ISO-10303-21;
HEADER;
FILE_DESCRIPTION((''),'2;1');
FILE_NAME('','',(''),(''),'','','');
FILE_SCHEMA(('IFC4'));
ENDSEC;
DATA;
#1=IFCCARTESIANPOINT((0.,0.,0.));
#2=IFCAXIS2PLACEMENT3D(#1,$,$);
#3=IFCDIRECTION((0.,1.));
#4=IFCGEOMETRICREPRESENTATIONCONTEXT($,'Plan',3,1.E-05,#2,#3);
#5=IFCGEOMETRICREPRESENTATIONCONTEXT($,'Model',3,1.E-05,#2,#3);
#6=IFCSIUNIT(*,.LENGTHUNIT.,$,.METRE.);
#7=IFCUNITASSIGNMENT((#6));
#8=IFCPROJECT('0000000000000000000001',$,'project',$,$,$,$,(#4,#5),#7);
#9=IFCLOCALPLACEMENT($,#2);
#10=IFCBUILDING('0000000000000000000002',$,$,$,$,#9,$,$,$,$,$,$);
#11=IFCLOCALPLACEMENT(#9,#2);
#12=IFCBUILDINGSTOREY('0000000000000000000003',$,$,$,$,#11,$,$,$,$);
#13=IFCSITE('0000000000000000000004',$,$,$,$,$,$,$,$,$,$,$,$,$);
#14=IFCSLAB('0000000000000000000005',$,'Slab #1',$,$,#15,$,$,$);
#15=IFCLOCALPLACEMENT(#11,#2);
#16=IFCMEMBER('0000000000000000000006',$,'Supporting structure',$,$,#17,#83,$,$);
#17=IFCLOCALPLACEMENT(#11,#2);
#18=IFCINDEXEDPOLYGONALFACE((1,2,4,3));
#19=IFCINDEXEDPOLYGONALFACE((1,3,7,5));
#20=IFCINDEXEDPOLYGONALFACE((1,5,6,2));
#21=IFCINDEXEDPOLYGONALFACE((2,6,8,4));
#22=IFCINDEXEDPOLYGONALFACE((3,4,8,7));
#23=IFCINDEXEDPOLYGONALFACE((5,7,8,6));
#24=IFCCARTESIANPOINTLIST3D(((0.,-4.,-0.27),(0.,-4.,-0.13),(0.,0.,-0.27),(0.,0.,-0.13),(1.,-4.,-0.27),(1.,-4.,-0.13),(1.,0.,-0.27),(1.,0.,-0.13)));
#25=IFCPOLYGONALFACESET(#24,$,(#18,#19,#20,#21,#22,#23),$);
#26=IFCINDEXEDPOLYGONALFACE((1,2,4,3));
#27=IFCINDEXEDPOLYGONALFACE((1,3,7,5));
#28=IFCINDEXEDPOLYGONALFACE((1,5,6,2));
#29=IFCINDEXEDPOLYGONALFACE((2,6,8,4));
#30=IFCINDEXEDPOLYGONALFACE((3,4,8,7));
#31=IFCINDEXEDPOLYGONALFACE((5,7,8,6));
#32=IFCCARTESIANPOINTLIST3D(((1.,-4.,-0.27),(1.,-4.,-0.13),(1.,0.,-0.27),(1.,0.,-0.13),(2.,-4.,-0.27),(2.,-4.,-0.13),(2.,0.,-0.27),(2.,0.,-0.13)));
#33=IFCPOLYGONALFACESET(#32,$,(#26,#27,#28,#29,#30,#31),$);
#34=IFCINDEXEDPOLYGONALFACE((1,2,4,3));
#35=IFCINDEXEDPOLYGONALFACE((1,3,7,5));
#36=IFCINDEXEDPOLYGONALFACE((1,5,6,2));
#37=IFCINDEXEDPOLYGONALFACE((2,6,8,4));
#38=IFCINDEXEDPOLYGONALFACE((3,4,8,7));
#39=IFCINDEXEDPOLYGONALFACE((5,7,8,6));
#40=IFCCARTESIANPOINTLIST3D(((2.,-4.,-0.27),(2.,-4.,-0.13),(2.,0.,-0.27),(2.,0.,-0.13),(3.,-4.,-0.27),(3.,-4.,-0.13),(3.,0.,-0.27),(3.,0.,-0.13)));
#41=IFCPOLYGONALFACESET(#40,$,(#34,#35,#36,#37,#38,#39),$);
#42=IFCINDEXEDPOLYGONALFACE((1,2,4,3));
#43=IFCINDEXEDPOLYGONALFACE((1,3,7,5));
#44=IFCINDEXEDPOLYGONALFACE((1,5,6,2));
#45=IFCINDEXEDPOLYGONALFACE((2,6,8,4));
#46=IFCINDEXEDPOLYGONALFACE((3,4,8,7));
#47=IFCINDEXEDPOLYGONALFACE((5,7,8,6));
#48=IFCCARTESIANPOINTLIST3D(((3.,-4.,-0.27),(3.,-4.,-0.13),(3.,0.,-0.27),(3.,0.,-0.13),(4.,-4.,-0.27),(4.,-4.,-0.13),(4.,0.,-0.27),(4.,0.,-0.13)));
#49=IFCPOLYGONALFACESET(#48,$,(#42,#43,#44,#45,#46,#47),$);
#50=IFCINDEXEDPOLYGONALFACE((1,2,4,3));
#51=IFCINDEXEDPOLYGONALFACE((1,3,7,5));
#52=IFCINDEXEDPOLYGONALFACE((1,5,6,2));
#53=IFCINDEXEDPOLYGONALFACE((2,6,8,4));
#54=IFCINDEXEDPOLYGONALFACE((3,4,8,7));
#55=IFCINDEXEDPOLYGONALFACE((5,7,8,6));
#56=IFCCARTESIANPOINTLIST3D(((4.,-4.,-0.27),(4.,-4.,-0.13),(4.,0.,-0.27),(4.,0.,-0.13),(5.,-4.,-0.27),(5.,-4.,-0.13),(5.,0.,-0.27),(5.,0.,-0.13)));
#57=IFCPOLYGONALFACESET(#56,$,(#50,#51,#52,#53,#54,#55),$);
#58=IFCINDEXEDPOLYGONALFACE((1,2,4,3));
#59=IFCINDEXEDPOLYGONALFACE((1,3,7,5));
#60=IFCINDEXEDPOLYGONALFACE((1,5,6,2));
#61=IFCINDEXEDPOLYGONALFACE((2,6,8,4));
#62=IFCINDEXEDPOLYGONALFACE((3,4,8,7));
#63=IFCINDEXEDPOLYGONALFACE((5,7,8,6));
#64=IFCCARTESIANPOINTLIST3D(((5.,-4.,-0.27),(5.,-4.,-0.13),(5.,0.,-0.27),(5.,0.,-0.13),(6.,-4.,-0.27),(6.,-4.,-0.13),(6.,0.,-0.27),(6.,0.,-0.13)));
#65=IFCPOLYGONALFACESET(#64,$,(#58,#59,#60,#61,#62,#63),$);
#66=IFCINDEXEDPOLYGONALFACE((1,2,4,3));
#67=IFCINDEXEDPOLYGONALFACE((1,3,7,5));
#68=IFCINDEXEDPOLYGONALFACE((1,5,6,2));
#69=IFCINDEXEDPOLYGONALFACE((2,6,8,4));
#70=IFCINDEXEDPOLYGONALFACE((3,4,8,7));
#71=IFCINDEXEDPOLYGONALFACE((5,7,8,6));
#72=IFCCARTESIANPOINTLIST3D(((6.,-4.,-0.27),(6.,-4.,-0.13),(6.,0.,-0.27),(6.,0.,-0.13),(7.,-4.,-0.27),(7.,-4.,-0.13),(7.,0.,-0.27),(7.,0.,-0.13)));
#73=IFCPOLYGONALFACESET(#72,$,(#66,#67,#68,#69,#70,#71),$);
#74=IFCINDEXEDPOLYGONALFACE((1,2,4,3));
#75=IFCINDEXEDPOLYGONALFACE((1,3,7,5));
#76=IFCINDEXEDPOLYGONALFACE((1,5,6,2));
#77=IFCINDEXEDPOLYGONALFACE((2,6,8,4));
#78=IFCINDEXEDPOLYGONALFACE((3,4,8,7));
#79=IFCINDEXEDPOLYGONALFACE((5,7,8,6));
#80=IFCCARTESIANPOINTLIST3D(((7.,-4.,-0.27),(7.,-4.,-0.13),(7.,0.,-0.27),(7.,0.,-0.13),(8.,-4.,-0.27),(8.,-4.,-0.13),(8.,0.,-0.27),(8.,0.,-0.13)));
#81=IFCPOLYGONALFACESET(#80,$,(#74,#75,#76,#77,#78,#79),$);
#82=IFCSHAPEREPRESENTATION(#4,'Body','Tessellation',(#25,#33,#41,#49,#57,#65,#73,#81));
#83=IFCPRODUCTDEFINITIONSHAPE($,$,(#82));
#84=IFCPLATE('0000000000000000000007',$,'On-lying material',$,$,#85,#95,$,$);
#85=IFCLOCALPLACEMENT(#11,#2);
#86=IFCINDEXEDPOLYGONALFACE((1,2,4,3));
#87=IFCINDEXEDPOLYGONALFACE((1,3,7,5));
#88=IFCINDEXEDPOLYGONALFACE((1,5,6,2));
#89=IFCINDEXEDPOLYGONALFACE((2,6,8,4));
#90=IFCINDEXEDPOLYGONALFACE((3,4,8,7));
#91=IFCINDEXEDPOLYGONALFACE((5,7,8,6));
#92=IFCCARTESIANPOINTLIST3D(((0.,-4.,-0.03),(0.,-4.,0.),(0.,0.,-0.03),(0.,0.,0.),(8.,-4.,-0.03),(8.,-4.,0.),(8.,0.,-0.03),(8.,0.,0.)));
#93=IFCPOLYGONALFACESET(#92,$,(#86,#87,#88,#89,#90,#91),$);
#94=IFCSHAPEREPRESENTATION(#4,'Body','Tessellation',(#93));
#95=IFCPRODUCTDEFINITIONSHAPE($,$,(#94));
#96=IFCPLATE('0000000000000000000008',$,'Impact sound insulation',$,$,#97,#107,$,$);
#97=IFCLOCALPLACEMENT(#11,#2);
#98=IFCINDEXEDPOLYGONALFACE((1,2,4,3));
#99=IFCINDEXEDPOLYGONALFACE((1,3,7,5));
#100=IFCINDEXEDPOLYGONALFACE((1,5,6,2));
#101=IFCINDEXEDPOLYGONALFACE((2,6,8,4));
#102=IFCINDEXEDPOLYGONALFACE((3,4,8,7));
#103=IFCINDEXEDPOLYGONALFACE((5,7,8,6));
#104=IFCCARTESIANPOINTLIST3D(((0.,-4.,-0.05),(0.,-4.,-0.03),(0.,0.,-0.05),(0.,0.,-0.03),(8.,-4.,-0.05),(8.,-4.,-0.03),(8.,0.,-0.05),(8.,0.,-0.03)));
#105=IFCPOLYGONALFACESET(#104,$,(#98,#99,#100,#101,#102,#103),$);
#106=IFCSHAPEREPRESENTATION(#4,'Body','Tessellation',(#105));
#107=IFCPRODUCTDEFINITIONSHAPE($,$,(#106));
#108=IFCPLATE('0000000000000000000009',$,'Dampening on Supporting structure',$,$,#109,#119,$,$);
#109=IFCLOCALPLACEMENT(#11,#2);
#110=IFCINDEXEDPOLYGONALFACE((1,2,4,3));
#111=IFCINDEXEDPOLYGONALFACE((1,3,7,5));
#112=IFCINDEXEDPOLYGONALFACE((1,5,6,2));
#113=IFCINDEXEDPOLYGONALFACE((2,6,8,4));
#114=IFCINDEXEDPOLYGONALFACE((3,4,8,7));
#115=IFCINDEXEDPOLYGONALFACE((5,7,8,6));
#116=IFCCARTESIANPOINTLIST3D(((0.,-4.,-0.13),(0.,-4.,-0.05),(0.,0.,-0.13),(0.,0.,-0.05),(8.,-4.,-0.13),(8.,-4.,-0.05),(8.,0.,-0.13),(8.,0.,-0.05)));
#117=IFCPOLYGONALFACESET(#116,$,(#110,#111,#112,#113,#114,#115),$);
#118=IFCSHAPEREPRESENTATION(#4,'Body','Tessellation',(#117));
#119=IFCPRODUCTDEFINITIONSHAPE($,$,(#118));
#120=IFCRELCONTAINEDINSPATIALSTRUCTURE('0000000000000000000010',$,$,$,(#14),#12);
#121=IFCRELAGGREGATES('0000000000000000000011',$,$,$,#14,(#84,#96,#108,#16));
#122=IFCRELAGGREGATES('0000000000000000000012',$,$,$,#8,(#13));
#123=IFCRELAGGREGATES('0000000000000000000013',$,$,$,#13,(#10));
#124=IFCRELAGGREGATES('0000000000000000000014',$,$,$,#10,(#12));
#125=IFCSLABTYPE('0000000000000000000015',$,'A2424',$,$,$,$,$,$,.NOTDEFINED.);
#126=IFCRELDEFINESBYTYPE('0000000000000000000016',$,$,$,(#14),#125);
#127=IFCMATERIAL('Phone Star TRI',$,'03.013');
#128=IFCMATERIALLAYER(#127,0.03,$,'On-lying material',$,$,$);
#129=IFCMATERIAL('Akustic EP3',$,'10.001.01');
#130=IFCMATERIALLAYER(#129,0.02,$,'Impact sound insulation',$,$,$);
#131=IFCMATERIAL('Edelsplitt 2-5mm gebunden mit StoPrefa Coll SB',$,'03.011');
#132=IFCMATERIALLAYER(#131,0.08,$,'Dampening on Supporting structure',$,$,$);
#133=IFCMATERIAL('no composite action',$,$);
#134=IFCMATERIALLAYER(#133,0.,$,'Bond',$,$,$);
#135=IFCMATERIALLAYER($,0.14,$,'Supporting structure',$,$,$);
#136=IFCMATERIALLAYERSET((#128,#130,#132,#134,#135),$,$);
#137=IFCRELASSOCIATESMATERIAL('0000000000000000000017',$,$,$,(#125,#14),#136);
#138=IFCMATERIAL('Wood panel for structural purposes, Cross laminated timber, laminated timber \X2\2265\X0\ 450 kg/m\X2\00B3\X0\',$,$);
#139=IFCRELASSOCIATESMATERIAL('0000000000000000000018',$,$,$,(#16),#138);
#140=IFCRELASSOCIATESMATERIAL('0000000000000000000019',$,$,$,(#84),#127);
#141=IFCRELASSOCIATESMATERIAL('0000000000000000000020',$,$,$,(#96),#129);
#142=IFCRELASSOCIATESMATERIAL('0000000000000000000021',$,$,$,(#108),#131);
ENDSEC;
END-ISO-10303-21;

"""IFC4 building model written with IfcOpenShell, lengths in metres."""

from ifc_helpers import new_model, si_unit, direction, frame, frame_2d, origin, origin_with_axes, place, context, project, spatial, rectangle, extrude, material, layer, layer_set, type_object, element, aggregate, save


model = new_model("IFC4")

# Units and contexts
plan_context = context("Plan", 3, precision=1e-05, world=origin(), true_north=direction((0.0, 1.0)))
model_context = context("Model", 3, precision=1e-05, world=origin(), true_north=direction((0.0, 1.0)))
ifc_project = project(units=[si_unit("LENGTHUNIT", "METRE")], contexts=[plan_context, model_context])

# Site, building, storey
site = spatial("IfcSite", under=ifc_project)
building_placement = place(None, origin())
building = spatial("IfcBuilding", under=site, at=building_placement)
storey_placement = place(building_placement, origin())
storey = spatial("IfcBuildingStorey", under=building, at=storey_placement)

# Slab, member, plates
ifc_material_1 = material(Name="Phone Star TRI", Category="03.013")
ifc_layer_1 = layer(ifc_material_1, 0.03, Name="On-lying material")
ifc_material_2 = material(Name="Akustic EP3", Category="10.001.01")
ifc_layer_2 = layer(ifc_material_2, 0.02, Name="Impact sound insulation")
ifc_material_3 = material(Name="Edelsplitt 2-5mm gebunden mit StoPrefa Coll SB", Category="03.011")
ifc_layer_3 = layer(ifc_material_3, 0.08, Name="Dampening on Supporting structure")
ifc_material_4 = material(Name="no composite action")
ifc_layer_4 = layer(ifc_material_4, 0.0, Name="Bond")
ifc_layer_5 = layer(None, 0.14, Name="Supporting structure")
ifc_layer_set = layer_set([ifc_layer_1, ifc_layer_2, ifc_layer_3, ifc_layer_4, ifc_layer_5])
slab_type = type_object("IfcSlabType", Name="A2424", PredefinedType="NOTDEFINED", material=ifc_layer_set)
slab_placement = place(None, frame((0.0, 0.0, 0.0), z_axis=(0.0, 0.0, -1.0), x_axis=(1.0, 0.0, 0.0)))
slab = element("IfcSlab", 1, at=slab_placement, inside=storey, type_object=slab_type, material=ifc_layer_set, Name="Slab #1")
ifc_material_5 = material(Name="Wood panel for structural purposes, Cross laminated timber, laminated timber ≥ 450 kg/m³")
member_placement = place(slab_placement, origin())
member = element("IfcMember", 2, at=member_placement, material=ifc_material_5, Name="Supporting structure", context=plan_context, shape_type="SweptSolid", body=[
    extrude(rectangle(XDim=1.0, YDim=0.14, at=frame_2d((0.5, 0.07), x_axis=(1.0, 0.0))), frame((0.0, 4.0, 0.13), z_axis=(0.0, -1.0, 0.0), x_axis=(1.0, 0.0, 0.0)), (0.0, 0.0, 1.0), 4.0),
    extrude(rectangle(XDim=1.0, YDim=0.14, at=frame_2d((0.5, 0.07), x_axis=(1.0, 0.0))), frame((1.0, 4.0, 0.13), z_axis=(0.0, -1.0, 0.0), x_axis=(1.0, 0.0, 0.0)), (0.0, 0.0, 1.0), 4.0),
    extrude(rectangle(XDim=1.0, YDim=0.14, at=frame_2d((0.5, 0.07), x_axis=(1.0, 0.0))), frame((2.0, 4.0, 0.13), z_axis=(0.0, -1.0, 0.0), x_axis=(1.0, 0.0, 0.0)), (0.0, 0.0, 1.0), 4.0),
    extrude(rectangle(XDim=1.0, YDim=0.14, at=frame_2d((0.5, 0.07), x_axis=(1.0, 0.0))), frame((3.0, 4.0, 0.13), z_axis=(0.0, -1.0, 0.0), x_axis=(1.0, 0.0, 0.0)), (0.0, 0.0, 1.0), 4.0),
    extrude(rectangle(XDim=1.0, YDim=0.14, at=frame_2d((0.5, 0.07), x_axis=(1.0, 0.0))), frame((4.0, 4.0, 0.13), z_axis=(0.0, -1.0, 0.0), x_axis=(1.0, 0.0, 0.0)), (0.0, 0.0, 1.0), 4.0),
    extrude(rectangle(XDim=1.0, YDim=0.14, at=frame_2d((0.5, 0.07), x_axis=(1.0, 0.0))), frame((5.0, 4.0, 0.13), z_axis=(0.0, -1.0, 0.0), x_axis=(1.0, 0.0, 0.0)), (0.0, 0.0, 1.0), 4.0),
    extrude(rectangle(XDim=1.0, YDim=0.14, at=frame_2d((0.5, 0.07), x_axis=(1.0, 0.0))), frame((6.0, 4.0, 0.13), z_axis=(0.0, -1.0, 0.0), x_axis=(1.0, 0.0, 0.0)), (0.0, 0.0, 1.0), 4.0),
    extrude(rectangle(XDim=1.0, YDim=0.14, at=frame_2d((0.5, 0.07), x_axis=(1.0, 0.0))), frame((7.0, 4.0, 0.13), z_axis=(0.0, -1.0, 0.0), x_axis=(1.0, 0.0, 0.0)), (0.0, 0.0, 1.0), 4.0),
])
plate_1_placement = place(slab_placement, origin())
plate_1 = element("IfcPlate", 3, at=plate_1_placement, material=ifc_material_1, Name="On-lying material", context=plan_context, shape_type="SweptSolid", body=[
    extrude(rectangle(XDim=8.0, YDim=4.0, at=frame_2d((4.0, 2.0), x_axis=(1.0, 0.0))), origin_with_axes(), (0.0, 0.0, 1.0), 0.03),
])
plate_2_placement = place(slab_placement, origin())
plate_2 = element("IfcPlate", 4, at=plate_2_placement, material=ifc_material_2, Name="Impact sound insulation", context=plan_context, shape_type="SweptSolid", body=[
    extrude(rectangle(XDim=8.0, YDim=4.0, at=frame_2d((4.0, 2.0), x_axis=(1.0, 0.0))), frame((0.0, 0.0, 0.03), z_axis=(0.0, 0.0, 1.0), x_axis=(1.0, 0.0, 0.0)), (0.0, 0.0, 1.0), 0.02),
])
plate_3_placement = place(slab_placement, origin())
plate_3 = element("IfcPlate", 5, at=plate_3_placement, material=ifc_material_3, Name="Dampening on Supporting structure", context=plan_context, shape_type="SweptSolid", body=[
    extrude(rectangle(XDim=8.0, YDim=4.0, at=frame_2d((4.0, 2.0), x_axis=(1.0, 0.0))), frame((0.0, 0.0, 0.05), z_axis=(0.0, 0.0, 1.0), x_axis=(1.0, 0.0, 0.0)), (0.0, 0.0, 1.0), 0.08),
])
aggregate(slab, [plate_1, plate_2, plate_3, member])

save(model, "model.ifc")
